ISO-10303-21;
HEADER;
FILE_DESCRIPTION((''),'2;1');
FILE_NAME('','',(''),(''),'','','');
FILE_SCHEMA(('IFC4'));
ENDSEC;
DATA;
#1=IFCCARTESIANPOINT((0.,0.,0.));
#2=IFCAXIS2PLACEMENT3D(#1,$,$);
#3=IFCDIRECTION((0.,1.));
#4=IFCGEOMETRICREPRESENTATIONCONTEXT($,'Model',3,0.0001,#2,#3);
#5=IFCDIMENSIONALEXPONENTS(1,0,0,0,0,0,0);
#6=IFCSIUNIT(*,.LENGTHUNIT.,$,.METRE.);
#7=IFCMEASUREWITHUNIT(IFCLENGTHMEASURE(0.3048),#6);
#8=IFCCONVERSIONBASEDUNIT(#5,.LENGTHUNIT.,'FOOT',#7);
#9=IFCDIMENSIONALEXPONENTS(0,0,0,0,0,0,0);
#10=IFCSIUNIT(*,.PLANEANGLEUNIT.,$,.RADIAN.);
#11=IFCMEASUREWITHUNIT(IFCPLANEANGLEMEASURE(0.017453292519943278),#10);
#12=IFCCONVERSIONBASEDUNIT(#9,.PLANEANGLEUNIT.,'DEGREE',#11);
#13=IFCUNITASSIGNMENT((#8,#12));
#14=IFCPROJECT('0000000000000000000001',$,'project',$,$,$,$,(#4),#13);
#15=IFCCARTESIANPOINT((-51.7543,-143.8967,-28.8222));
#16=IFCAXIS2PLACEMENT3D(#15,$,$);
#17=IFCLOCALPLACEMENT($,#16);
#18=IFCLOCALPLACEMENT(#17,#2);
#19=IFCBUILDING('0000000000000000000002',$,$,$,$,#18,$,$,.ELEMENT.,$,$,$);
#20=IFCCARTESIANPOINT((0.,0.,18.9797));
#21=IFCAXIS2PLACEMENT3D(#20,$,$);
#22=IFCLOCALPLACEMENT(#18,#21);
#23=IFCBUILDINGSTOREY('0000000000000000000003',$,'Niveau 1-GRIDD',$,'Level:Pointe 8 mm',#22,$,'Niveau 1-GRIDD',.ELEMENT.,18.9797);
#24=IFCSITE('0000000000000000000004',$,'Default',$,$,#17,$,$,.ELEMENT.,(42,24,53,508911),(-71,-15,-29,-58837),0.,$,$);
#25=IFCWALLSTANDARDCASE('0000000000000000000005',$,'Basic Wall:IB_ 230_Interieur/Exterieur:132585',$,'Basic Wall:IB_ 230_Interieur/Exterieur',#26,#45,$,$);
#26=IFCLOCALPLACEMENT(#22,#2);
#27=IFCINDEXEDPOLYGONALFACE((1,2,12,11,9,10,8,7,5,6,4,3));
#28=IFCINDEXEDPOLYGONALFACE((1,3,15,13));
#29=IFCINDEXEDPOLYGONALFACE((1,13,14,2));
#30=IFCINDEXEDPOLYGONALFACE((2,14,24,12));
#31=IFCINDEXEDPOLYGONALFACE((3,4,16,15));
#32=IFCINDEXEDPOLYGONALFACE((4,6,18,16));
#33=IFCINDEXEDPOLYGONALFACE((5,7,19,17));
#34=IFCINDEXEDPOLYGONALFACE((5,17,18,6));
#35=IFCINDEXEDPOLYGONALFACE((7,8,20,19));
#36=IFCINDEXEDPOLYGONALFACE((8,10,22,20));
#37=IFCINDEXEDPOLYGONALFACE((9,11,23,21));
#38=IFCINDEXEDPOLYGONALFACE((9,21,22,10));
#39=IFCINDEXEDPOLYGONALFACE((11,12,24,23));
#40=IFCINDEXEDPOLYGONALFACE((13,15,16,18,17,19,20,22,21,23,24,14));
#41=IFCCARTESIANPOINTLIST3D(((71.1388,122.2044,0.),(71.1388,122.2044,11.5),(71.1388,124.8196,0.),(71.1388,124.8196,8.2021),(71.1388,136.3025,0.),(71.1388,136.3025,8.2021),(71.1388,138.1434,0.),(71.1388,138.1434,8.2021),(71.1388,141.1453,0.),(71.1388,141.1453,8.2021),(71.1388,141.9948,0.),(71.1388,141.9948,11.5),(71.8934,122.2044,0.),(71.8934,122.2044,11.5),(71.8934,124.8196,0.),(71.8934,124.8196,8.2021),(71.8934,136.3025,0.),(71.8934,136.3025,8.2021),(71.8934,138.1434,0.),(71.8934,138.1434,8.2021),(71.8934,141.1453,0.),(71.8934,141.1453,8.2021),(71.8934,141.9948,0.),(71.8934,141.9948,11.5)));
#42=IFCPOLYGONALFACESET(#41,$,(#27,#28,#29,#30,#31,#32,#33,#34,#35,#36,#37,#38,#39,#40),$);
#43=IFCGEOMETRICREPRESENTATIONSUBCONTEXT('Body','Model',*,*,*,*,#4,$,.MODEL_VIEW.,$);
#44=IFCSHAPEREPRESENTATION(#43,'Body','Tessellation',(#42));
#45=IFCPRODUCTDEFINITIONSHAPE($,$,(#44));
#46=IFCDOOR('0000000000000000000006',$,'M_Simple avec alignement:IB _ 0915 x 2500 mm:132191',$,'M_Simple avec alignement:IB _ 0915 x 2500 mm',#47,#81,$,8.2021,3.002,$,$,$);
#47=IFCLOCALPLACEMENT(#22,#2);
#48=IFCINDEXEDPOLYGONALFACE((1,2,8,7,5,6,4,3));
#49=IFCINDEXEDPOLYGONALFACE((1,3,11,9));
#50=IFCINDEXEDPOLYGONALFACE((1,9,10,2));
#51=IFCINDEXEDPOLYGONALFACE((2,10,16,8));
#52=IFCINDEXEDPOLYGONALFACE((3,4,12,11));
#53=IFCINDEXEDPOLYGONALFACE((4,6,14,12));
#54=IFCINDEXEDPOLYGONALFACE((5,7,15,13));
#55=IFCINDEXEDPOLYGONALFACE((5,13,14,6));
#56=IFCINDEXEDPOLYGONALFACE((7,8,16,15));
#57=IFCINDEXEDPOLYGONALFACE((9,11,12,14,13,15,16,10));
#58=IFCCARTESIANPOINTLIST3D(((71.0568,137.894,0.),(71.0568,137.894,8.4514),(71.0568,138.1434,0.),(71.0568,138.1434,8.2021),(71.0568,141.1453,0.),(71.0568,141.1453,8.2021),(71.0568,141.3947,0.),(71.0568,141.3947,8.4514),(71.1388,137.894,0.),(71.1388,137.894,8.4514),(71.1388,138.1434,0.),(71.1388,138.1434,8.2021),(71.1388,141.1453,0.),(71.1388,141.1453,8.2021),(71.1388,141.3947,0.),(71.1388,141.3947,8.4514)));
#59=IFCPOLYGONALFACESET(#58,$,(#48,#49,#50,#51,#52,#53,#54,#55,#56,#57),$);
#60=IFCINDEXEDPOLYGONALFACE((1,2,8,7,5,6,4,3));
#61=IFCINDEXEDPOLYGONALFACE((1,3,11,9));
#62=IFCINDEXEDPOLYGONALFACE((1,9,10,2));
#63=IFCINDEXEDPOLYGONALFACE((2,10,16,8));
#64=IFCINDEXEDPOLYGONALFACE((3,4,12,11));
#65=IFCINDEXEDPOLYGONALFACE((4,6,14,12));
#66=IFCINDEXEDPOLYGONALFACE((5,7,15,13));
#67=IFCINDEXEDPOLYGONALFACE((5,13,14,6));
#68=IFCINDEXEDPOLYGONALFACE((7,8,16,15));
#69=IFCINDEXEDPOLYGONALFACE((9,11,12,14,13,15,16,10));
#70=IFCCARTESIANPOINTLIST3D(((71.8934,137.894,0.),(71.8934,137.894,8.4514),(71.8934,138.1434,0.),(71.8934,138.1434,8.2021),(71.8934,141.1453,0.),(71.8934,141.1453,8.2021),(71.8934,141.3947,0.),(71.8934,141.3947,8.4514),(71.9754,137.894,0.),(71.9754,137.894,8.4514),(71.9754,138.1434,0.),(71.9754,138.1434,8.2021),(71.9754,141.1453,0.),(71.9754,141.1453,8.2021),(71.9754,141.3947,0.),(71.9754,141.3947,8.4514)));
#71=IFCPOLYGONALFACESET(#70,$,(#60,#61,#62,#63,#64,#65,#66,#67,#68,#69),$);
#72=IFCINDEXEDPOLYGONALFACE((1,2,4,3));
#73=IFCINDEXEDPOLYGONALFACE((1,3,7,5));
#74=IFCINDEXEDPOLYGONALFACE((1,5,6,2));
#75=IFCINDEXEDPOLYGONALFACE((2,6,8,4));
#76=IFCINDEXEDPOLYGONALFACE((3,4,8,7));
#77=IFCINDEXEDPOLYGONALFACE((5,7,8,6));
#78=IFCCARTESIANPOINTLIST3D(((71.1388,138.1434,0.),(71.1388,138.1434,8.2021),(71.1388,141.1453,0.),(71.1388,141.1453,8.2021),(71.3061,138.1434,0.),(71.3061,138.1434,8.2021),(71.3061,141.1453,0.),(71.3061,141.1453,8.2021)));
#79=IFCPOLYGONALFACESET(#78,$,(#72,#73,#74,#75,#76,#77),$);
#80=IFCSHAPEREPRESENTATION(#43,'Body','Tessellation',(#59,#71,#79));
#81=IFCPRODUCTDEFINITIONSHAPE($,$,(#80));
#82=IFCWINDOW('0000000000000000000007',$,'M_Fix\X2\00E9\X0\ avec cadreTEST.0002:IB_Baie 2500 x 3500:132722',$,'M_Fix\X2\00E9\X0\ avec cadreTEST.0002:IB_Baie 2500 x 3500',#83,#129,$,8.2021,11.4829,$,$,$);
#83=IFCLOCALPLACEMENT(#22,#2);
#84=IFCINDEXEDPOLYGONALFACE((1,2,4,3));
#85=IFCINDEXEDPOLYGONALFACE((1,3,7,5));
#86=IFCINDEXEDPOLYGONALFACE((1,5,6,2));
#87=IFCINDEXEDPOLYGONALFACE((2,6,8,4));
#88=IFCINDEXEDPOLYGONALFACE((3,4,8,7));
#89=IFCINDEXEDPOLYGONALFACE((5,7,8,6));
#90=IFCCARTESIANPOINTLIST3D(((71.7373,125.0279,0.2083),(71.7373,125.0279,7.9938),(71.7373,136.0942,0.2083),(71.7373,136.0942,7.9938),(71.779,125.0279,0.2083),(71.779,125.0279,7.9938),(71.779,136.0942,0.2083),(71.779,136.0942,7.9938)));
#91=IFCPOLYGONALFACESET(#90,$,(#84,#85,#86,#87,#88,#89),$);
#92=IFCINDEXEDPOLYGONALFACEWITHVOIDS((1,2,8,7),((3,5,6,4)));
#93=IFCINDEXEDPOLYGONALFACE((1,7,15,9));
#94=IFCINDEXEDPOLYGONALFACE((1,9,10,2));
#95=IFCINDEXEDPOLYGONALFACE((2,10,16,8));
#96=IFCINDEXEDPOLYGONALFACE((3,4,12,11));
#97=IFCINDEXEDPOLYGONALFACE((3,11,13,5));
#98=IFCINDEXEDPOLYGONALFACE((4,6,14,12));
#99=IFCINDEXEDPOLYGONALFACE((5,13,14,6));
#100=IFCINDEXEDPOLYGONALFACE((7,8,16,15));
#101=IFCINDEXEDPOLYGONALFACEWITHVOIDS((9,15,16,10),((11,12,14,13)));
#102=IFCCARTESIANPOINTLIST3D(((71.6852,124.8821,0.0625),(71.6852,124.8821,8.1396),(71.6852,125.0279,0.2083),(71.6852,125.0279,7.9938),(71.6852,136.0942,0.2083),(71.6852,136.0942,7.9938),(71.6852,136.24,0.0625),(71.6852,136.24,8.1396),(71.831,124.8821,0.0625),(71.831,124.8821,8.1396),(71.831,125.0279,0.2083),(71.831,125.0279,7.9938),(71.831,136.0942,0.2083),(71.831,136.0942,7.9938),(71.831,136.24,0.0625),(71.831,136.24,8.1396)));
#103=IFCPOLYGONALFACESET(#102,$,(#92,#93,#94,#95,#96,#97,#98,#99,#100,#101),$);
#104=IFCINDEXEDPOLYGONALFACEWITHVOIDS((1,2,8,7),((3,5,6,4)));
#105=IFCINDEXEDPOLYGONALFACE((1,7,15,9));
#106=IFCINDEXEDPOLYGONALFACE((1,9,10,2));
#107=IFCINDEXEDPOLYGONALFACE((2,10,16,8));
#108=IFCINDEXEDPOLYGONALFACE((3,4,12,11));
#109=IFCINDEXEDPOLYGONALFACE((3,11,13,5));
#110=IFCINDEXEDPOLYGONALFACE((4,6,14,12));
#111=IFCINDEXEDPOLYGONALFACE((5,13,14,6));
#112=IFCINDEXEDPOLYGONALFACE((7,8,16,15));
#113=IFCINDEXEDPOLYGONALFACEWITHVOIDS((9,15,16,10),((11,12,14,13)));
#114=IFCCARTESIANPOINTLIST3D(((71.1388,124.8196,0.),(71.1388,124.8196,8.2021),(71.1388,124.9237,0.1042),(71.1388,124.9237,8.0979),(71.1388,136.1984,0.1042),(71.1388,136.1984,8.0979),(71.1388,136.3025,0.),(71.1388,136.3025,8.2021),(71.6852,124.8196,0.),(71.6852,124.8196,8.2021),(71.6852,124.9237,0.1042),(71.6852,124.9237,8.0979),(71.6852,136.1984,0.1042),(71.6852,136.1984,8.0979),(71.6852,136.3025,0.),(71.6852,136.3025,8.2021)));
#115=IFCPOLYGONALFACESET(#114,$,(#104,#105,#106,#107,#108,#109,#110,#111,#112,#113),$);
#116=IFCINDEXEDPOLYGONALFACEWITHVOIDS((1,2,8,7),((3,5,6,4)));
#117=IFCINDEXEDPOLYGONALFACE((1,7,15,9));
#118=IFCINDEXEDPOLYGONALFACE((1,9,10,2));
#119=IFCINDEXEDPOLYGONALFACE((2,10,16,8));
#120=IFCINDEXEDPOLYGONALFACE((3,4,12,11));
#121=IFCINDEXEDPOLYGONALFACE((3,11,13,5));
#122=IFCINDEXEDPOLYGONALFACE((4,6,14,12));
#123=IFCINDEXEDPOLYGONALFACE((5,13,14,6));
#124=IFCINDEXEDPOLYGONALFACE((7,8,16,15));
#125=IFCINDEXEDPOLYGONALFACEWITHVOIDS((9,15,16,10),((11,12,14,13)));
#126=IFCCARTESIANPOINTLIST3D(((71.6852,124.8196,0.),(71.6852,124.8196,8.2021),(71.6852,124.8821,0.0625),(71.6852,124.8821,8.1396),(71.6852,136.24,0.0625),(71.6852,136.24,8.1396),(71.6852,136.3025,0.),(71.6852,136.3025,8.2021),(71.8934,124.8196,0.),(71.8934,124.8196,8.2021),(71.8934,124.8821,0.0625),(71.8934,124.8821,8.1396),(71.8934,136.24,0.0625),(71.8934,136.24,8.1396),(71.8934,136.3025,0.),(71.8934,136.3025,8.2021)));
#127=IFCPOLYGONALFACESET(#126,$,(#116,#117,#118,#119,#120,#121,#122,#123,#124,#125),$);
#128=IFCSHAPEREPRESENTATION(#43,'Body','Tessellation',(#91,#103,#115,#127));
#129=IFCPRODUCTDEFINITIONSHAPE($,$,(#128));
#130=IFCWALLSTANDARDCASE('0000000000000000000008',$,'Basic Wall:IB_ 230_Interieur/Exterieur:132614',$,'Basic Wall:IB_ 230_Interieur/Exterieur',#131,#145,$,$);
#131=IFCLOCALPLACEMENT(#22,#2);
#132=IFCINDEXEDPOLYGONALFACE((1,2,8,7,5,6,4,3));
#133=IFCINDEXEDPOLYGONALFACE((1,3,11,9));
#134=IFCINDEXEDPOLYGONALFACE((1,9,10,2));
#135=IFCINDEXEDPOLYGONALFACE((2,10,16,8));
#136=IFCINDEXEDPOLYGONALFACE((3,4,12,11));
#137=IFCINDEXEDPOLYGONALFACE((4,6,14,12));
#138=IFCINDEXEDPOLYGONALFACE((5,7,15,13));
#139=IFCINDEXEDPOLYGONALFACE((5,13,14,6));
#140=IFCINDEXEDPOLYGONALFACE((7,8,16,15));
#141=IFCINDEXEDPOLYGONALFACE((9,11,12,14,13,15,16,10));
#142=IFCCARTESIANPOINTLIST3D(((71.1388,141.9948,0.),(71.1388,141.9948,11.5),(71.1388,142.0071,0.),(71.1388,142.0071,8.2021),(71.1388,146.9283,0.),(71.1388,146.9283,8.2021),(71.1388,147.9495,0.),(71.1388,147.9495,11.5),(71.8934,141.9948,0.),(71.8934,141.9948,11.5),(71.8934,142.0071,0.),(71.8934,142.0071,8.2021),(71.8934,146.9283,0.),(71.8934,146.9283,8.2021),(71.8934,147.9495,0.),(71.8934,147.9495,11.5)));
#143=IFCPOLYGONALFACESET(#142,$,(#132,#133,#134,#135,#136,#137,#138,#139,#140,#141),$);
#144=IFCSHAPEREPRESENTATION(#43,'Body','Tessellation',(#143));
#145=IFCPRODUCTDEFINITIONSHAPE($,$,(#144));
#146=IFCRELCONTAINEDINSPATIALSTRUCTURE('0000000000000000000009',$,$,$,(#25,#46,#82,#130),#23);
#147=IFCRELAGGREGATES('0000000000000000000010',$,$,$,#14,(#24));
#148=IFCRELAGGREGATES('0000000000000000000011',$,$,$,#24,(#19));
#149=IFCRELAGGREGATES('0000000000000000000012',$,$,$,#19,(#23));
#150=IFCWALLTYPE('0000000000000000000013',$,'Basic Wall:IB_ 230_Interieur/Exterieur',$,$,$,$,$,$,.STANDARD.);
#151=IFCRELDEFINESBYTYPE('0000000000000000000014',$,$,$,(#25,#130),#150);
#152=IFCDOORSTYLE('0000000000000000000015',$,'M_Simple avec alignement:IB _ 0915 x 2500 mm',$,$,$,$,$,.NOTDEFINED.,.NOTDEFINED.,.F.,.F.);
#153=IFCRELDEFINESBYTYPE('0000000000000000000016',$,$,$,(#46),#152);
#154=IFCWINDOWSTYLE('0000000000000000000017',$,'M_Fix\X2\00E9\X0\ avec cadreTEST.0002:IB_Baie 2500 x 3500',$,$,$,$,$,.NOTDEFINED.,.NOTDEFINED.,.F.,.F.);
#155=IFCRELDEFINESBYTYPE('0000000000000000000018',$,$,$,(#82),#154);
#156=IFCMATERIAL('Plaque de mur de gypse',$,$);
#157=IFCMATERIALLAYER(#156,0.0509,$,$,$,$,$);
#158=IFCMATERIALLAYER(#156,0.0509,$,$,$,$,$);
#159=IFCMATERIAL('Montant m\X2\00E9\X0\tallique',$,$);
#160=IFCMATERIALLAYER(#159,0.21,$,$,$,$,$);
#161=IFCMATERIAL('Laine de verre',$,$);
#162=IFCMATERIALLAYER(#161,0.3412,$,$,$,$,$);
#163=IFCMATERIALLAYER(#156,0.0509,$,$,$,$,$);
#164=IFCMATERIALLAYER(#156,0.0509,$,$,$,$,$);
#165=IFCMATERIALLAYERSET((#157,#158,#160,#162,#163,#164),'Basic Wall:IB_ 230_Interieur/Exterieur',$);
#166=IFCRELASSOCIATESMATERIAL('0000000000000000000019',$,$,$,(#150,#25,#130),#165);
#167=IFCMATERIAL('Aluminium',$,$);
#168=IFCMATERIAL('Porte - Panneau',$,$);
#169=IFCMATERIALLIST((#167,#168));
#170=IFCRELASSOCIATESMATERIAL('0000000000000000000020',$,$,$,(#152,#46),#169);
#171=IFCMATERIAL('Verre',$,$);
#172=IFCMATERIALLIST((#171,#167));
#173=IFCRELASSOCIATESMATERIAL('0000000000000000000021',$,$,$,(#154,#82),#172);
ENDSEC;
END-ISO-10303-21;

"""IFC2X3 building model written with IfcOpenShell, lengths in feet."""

from ifc_helpers import new_model, entity, si_unit, converted_unit, direction, frame, frame_2d, origin, place, context, subcontext, project, spatial, polyline, rectangle, outline, extrude, source, transform, mapped, material, material_list, layer, layer_set, layer_usage, type_object, type_shapes, element, fill, save


model = new_model("IFC2X3")

# Units and contexts
model_context = context("Model", 3, precision=0.0001, world=origin(), true_north=direction((0.0, 1.0)))
body_context = subcontext(model_context, "Body", "Model", "MODEL_VIEW")
ifc_project = project(units=[converted_unit("LENGTHUNIT", "FOOT", entity("IfcLengthMeasure", 0.3048), si_unit("LENGTHUNIT", "METRE"), dimensions=[1, 0, 0, 0, 0, 0, 0]), converted_unit("PLANEANGLEUNIT", "DEGREE", entity("IfcPlaneAngleMeasure", 0.017453292519943278), si_unit("PLANEANGLEUNIT", "RADIAN"), dimensions=[0, 0, 0, 0, 0, 0, 0])], contexts=[model_context])

# Site, building, storey
site_placement = place(None, frame((-51.7543, -143.8967, -28.8222)))
site = spatial("IfcSite", under=ifc_project, at=site_placement, Name="Default", CompositionType="ELEMENT", RefLatitude=(42, 24, 53, 508911), RefLongitude=(-71, -15, -29, -58837), RefElevation=0.0)
building_placement = place(site_placement, origin())
building = spatial("IfcBuilding", under=site, at=building_placement, CompositionType="ELEMENT")
storey_placement = place(building_placement, frame((0.0, 0.0, 18.9797)))
storey = spatial("IfcBuildingStorey", under=building, at=storey_placement, Name="Niveau 1-GRIDD", ObjectType="Level:Pointe 8 mm", LongName="Niveau 1-GRIDD", CompositionType="ELEMENT", Elevation=18.9797)

# Wall, openings, door, window
ifc_material_1 = material(Name="Plaque de mur de gypse")
ifc_layer_1 = layer(ifc_material_1, 0.0509)
ifc_layer_2 = layer(ifc_material_1, 0.0509)
ifc_material_2 = material(Name="Montant métallique")
ifc_layer_3 = layer(ifc_material_2, 0.21)
ifc_material_3 = material(Name="Laine de verre")
ifc_layer_4 = layer(ifc_material_3, 0.3412)
ifc_layer_5 = layer(ifc_material_1, 0.0509)
ifc_layer_6 = layer(ifc_material_1, 0.0509)
ifc_layer_set_1 = layer_set([ifc_layer_1, ifc_layer_2, ifc_layer_3, ifc_layer_4, ifc_layer_5, ifc_layer_6], Name="Basic Wall:IB_ 230_Interieur/Exterieur")
ifc_layer_usage_1 = layer_usage(ifc_layer_set_1, "AXIS2", "NEGATIVE", 0.3773)
wall_type_1 = type_object("IfcWallType", Name="Basic Wall:IB_ 230_Interieur/Exterieur", PredefinedType="STANDARD", material=ifc_layer_set_1)
wall_1_placement = place(storey_placement, frame((71.5161, 141.9948, 0.0), z_axis=(0.0, 0.0, 1.0), x_axis=(0.0, -1.0, 0.0)))
wall_1 = element("IfcWallStandardCase", 1, at=wall_1_placement, inside=storey, type_object=wall_type_1, material=ifc_layer_usage_1, Name="Basic Wall:IB_ 230_Interieur/Exterieur:132585", ObjectType="Basic Wall:IB_ 230_Interieur/Exterieur", context=body_context, shape_type="SweptSolid", body=[
    extrude(rectangle(XDim=19.7904, YDim=0.7546, at=frame_2d((9.8952, 0.0), x_axis=(-1.0, 0.0))), origin(), (0.0, 0.0, 1.0), 11.5),
])
opening_1_placement = place(wall_1_placement, frame((3.8514, 0.3773, 0.0)))
opening_1 = element("IfcOpeningElement", 2, at=opening_1_placement, cuts=wall_1, ObjectType="Opening", context=body_context, shape_type="SweptSolid", body=[
    extrude(rectangle(XDim=3.002, YDim=8.2021, at=frame_2d((4.101, 1.501), x_axis=(0.0, 1.0))), frame((0.0, 0.0, 0.0), z_axis=(0.0, -1.0, 0.0), x_axis=(0.0, 0.0, 1.0)), (0.0, 0.0, 1.0), 0.7546),
])
opening_2_placement = place(wall_1_placement, frame((141.9948, -71.5161, 0.0), z_axis=(0.0, 0.0, 1.0), x_axis=(0.0, 1.0, 0.0)))
element("IfcOpeningElement", 3, at=opening_2_placement, cuts=wall_1, ObjectType="Opening", context=body_context, shape_type="SweptSolid", body=[
    extrude(rectangle(XDim=8.2021, YDim=3.002, at=frame_2d((0.0, 0.0), x_axis=(0.0, 1.0))), frame((66.8934, 139.6444, 4.101), z_axis=(1.0, 0.0, 0.0), x_axis=(0.0, 1.0, 0.0)), (0.0, 0.0, 1.0), 10.0),
])
opening_3_placement = place(wall_1_placement, frame((5.6922, -0.3773, 0.0)))
opening_3 = element("IfcOpeningElement", 4, at=opening_3_placement, cuts=wall_1, ObjectType="Opening", context=body_context, shape_type="SweptSolid", body=[
    extrude(rectangle(XDim=8.2021, YDim=11.4829, at=frame_2d((4.101, 5.7415), x_axis=(-1.0, 0.0))), frame((0.0, 0.0, 0.0), z_axis=(0.0, 1.0, 0.0), x_axis=(0.0, 0.0, 1.0)), (0.0, 0.0, 1.0), 0.7546),
])
ifc_material_4 = material(Name="Aluminium")
ifc_material_5 = material(Name="Porte - Panneau")
ifc_material_list_1 = material_list([ifc_material_4, ifc_material_5])
door_style = type_object("IfcDoorStyle", Name="M_Simple avec alignement:IB _ 0915 x 2500 mm", ConstructionType="NOTDEFINED", OperationType="NOTDEFINED", ParameterTakesPrecedence=False, Sizeable=False, material=ifc_material_list_1)
shared_shape_1 = source(origin(), body_context, "Body", "SweptSolid", [
    extrude(outline(polyline([(-1.7503, -4.2881), (1.7503, -4.2881), (1.7503, 4.1634), (1.501, 4.1634), (1.501, -4.0387), (-1.501, -4.0387), (-1.501, 4.1634), (-1.7503, 4.1634), (-1.7503, -4.2881)])), frame((1.501, 0.7546, 4.1634), z_axis=(0.0, 1.0, 0.0), x_axis=(1.0, 0.0, 0.0)), (0.0, 0.0, 1.0), 0.082),
    extrude(outline(polyline([(-4.2881, -1.7503), (4.1634, -1.7503), (4.1634, -1.501), (-4.0387, -1.501), (-4.0387, 1.501), (4.1634, 1.501), (4.1634, 1.7503), (-4.2881, 1.7503), (-4.2881, -1.7503)])), frame((1.501, -0.082, 4.1634), z_axis=(0.0, 1.0, 0.0), x_axis=(0.0, 0.0, -1.0)), (0.0, 0.0, 1.0), 0.082),
    extrude(rectangle(XDim=0.1673, YDim=3.002, at=frame_2d((0.0, 0.0), x_axis=(1.0, 0.0))), frame((1.501, 0.6709, 0.0), z_axis=(0.0, 0.0, 1.0), x_axis=(0.0, 1.0, 0.0)), (0.0, 0.0, 1.0), 8.2021),
])
type_shapes(door_style, [shared_shape_1])
door_placement = place(opening_1_placement, frame((0.0, 0.0, 0.0), z_axis=(0.0, 0.0, 1.0), x_axis=(-1.0, 0.0, 0.0)))
door = element("IfcDoor", 5, at=door_placement, inside=storey, type_object=door_style, material=ifc_material_list_1, Name="M_Simple avec alignement:IB _ 0915 x 2500 mm:132191", ObjectType="M_Simple avec alignement:IB _ 0915 x 2500 mm", OverallHeight=8.2021, OverallWidth=3.002, context=body_context, shape_type="MappedRepresentation", body=[
    mapped(shared_shape_1, transform((0.0, 0.0, 0.0), scale=1.0)),
])
fill(opening_1, door)
ifc_material_6 = material(Name="Verre")
ifc_material_list_2 = material_list([ifc_material_6, ifc_material_4])
window_style_1 = type_object("IfcWindowStyle", Name="M_Fixé avec cadreTEST.0002:IB_Baie 2500 x 3500", ConstructionType="NOTDEFINED", OperationType="NOTDEFINED", ParameterTakesPrecedence=False, Sizeable=False, material=ifc_material_list_2)
shared_shape_2 = source(origin(), body_context, "Body", "SweptSolid", [
    extrude(rectangle(XDim=0.0417, YDim=11.0663, at=frame_2d((0.0, 0.0), x_axis=(1.0, 0.0))), frame((5.7415, 0.6193, 0.2083), z_axis=(0.0, 0.0, 1.0), x_axis=(0.0, 1.0, 0.0)), (0.0, 0.0, 1.0), 7.7854),
    extrude(outline(polyline([(-5.679, -4.0385), (5.679, -4.0385), (5.679, 4.0385), (-5.679, 4.0385), (-5.679, -4.0385)]), holes=[polyline([(-5.5331, -3.8927), (-5.5331, 3.8927), (5.5331, 3.8927), (5.5331, -3.8927), (-5.5331, -3.8927)])]), frame((5.7415, 0.5464, 4.101), z_axis=(0.0, 1.0, 0.0), x_axis=(1.0, 0.0, 0.0)), (0.0, 0.0, 1.0), 0.1458),
    extrude(outline(polyline([(-5.7415, -4.101), (5.7415, -4.101), (5.7415, 4.101), (-5.7415, 4.101), (-5.7415, -4.101)]), holes=[polyline([(-5.6373, -3.9969), (-5.6373, 3.9969), (5.6373, 3.9969), (5.6373, -3.9969), (-5.6373, -3.9969)])]), frame((5.7415, 0.0, 4.101), z_axis=(0.0, 1.0, 0.0), x_axis=(1.0, 0.0, 0.0)), (0.0, 0.0, 1.0), 0.5464),
    extrude(outline(polyline([(-4.101, -5.7415), (4.101, -5.7415), (4.101, 5.7415), (-4.101, 5.7415), (-4.101, -5.7415)]), holes=[polyline([(-4.0385, -5.679), (-4.0385, 5.679), (4.0385, 5.679), (4.0385, -5.679), (-4.0385, -5.679)])]), frame((5.7415, 0.5464, 4.101), z_axis=(0.0, 1.0, 0.0), x_axis=(0.0, 0.0, -1.0)), (0.0, 0.0, 1.0), 0.2082),
])
type_shapes(window_style_1, [shared_shape_2])
window_1_placement = place(opening_3_placement, origin())
window_1 = element("IfcWindow", 6, at=window_1_placement, inside=storey, type_object=window_style_1, material=ifc_material_list_2, Name="M_Fixé avec cadreTEST.0002:IB_Baie 2500 x 3500:132722", ObjectType="M_Fixé avec cadreTEST.0002:IB_Baie 2500 x 3500", OverallHeight=8.2021, OverallWidth=11.4829, context=body_context, shape_type="MappedRepresentation", body=[
    mapped(shared_shape_2, transform((0.0, 0.0, 0.0), scale=1.0)),
])
fill(opening_3, window_1)

# Wall, opening
ifc_layer_usage_2 = layer_usage(ifc_layer_set_1, "AXIS2", "NEGATIVE", 0.3773)
wall_2_placement = place(storey_placement, frame((71.5161, 147.9495, 0.0), z_axis=(0.0, 0.0, 1.0), x_axis=(0.0, -1.0, 0.0)))
wall_2 = element("IfcWallStandardCase", 7, at=wall_2_placement, inside=storey, type_object=wall_type_1, material=ifc_layer_usage_2, Name="Basic Wall:IB_ 230_Interieur/Exterieur:132614", ObjectType="Basic Wall:IB_ 230_Interieur/Exterieur", context=body_context, shape_type="SweptSolid", body=[
    extrude(rectangle(XDim=5.9548, YDim=0.7546, at=frame_2d((2.9774, 0.0), x_axis=(-1.0, 0.0))), origin(), (0.0, 0.0, 1.0), 11.5),
])
opening_4_placement = place(wall_2_placement, origin())
element("IfcOpeningElement", 8, at=opening_4_placement, cuts=wall_2, ObjectType="Opening", context=body_context, shape_type="SweptSolid", body=[
    extrude(rectangle(XDim=8.2021, YDim=4.9213, at=frame_2d((0.0, 0.0), x_axis=(1.0, 0.0))), frame((3.4818, -5.3773, 4.101), z_axis=(0.0, 1.0, 0.0), x_axis=(0.0, 0.0, -1.0)), (0.0, 0.0, 1.0), 10.0),
])

save(model, "model.ifc")
